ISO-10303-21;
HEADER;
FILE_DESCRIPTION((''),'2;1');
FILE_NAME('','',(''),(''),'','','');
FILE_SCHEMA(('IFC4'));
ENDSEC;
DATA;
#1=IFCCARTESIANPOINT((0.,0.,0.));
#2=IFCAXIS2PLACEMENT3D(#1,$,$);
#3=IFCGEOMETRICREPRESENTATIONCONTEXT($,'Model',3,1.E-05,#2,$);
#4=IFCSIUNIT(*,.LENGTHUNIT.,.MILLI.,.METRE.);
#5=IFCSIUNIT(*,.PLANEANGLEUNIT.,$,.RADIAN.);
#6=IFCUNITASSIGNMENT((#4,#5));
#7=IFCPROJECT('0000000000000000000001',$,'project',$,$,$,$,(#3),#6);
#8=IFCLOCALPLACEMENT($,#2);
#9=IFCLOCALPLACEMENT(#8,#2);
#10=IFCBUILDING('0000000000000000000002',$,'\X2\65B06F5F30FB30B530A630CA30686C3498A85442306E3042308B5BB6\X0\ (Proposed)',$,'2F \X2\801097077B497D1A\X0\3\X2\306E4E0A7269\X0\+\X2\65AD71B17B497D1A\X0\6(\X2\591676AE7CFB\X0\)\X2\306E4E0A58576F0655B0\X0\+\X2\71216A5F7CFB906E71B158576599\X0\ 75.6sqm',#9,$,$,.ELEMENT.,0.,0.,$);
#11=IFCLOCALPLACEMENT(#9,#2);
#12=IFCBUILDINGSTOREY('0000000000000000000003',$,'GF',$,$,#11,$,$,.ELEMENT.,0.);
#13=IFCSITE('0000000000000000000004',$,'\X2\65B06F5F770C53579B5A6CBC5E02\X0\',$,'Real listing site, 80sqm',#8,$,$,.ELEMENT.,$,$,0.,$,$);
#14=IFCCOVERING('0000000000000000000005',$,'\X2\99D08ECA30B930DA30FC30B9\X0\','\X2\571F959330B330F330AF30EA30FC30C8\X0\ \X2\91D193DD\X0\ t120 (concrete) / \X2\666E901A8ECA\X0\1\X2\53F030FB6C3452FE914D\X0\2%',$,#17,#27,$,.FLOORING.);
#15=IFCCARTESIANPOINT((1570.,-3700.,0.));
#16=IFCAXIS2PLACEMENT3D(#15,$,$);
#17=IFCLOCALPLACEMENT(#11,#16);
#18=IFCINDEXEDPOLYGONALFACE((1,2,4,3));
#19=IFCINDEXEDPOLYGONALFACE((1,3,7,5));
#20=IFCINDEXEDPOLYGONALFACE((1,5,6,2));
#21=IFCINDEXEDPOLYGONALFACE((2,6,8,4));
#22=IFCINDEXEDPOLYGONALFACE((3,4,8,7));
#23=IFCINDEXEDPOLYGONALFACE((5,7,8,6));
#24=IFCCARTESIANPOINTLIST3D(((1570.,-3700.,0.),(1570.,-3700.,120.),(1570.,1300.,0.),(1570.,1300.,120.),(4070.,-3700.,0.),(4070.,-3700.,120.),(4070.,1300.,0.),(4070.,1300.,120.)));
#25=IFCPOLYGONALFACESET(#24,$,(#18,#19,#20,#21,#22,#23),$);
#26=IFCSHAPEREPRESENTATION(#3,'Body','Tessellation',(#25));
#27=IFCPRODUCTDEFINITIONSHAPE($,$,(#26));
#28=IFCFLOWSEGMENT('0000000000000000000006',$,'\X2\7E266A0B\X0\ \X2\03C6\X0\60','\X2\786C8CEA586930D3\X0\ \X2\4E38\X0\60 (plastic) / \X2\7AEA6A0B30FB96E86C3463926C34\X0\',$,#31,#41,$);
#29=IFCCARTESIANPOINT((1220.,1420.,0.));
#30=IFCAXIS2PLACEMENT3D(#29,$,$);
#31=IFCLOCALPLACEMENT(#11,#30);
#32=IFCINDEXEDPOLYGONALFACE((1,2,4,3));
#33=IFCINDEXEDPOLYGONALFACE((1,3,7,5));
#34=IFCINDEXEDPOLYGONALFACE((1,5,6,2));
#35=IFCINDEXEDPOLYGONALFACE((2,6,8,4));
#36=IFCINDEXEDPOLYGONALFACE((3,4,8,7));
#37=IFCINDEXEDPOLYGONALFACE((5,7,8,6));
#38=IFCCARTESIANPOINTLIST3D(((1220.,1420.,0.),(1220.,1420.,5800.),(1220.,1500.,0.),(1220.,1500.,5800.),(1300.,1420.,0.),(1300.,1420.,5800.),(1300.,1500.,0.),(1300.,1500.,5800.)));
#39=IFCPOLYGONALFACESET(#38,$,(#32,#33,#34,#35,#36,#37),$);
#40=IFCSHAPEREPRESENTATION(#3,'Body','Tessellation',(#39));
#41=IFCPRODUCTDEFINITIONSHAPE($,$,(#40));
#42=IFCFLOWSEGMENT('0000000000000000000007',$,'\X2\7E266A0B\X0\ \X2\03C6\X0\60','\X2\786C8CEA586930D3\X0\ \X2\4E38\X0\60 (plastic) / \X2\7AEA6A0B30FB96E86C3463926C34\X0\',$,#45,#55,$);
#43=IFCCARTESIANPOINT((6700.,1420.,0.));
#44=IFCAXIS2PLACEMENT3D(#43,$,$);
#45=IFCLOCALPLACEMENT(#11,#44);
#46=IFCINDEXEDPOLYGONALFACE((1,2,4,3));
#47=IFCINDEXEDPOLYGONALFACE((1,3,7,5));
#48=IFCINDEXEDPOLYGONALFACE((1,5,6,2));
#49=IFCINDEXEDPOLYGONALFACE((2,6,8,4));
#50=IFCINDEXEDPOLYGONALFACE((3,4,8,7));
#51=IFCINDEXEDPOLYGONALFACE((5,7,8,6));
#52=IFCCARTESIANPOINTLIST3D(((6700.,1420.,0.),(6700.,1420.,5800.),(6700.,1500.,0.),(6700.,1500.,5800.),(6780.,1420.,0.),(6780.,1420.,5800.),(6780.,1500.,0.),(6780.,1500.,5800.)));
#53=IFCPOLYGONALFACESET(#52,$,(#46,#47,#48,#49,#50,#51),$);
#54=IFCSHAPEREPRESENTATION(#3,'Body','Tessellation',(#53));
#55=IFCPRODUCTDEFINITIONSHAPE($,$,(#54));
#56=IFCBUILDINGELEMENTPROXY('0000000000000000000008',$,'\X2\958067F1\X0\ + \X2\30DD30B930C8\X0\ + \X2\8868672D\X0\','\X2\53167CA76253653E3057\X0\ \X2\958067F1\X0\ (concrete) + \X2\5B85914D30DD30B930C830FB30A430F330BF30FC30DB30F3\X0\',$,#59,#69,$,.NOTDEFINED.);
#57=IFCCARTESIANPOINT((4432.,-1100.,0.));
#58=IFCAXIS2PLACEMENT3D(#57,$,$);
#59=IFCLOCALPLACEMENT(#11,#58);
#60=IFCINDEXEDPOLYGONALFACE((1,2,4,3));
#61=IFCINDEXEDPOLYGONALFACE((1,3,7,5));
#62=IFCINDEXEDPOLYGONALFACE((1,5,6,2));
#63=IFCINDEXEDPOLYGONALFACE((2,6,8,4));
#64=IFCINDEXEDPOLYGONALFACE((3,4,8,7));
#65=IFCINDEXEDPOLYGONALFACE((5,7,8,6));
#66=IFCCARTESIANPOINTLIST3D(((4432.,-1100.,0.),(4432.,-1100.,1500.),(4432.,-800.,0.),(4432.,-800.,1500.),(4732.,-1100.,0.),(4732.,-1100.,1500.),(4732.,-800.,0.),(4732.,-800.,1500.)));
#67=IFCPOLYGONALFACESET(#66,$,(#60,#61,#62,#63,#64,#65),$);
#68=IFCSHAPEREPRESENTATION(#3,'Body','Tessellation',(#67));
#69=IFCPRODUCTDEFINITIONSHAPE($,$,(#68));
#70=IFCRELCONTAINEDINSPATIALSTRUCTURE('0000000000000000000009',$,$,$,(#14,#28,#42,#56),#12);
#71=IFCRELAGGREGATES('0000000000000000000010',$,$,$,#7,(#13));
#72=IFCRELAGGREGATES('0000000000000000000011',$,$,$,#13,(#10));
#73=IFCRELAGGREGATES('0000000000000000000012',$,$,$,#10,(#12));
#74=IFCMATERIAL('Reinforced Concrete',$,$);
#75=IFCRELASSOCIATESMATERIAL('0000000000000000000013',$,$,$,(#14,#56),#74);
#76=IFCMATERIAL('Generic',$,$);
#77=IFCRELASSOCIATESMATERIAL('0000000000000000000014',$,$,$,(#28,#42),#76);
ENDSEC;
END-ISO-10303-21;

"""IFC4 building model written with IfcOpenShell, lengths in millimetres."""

from ifc_helpers import new_model, si_unit, frame, frame_2d, origin, place, context, project, spatial, rectangle, extrude, material, element, save


model = new_model("IFC4")

# Units and contexts
model_context = context("Model", 3, precision=1e-05, world=origin())
ifc_project = project(units=[si_unit("LENGTHUNIT", "METRE", prefix="MILLI"), si_unit("PLANEANGLEUNIT", "RADIAN")], contexts=[model_context])

# Site, building, storey
site_placement = place(None, origin())
site = spatial("IfcSite", under=ifc_project, at=site_placement, Name="新潟県南魚沼市", ObjectType="Real listing site, 80sqm", CompositionType="ELEMENT", RefElevation=0.0)
building_placement = place(site_placement, origin())
building = spatial("IfcBuilding", under=site, at=building_placement, Name="新潟・サウナと水風呂のある家 (Proposed)", ObjectType="2F 耐震等級3の上物+断熱等級6(外皮系)の上塗漆喰+無機系遮熱塗料 75.6sqm", CompositionType="ELEMENT", ElevationOfRefHeight=0.0, ElevationOfTerrain=0.0)
storey_placement = place(building_placement, origin())
storey = spatial("IfcBuildingStorey", under=building, at=storey_placement, Name="GF", CompositionType="ELEMENT", Elevation=0.0)

# Shared definitions
ifc_material_1 = material(Name="Reinforced Concrete")

# Covering
covering_1_placement = place(storey_placement, frame((1570.0, -3700.0, 0.0)))
element("IfcCovering", 1, at=covering_1_placement, inside=storey, material=ifc_material_1, Name="駐車スペース", Description="土間コンクリート 金鏝 t120 (concrete) / 普通車1台・水勾配2%", PredefinedType="FLOORING", context=model_context, shape_type="SweptSolid", body=[
    extrude(rectangle(XDim=2500.0, YDim=5000.0, at=frame_2d((1250.0, 2500.0))), frame((1570.0, -3700.0, 0.0)), (0.0, 0.0, 1.0), 120.0),
])

# Flow segments
ifc_material_2 = material(Name="Generic")
flow_segment_1_placement = place(storey_placement, frame((1220.0, 1420.0, 0.0)))
element("IfcFlowSegment", 2, at=flow_segment_1_placement, inside=storey, material=ifc_material_2, Name="縦樋 φ60", Description="硬質塩ビ 丸60 (plastic) / 竪樋・雨水排水", context=model_context, shape_type="SweptSolid", body=[
    extrude(rectangle(XDim=80.0, YDim=80.0, at=frame_2d((40.0, 40.0))), frame((1220.0, 1420.0, 0.0)), (0.0, 0.0, 1.0), 5800.0),
])
flow_segment_2_placement = place(storey_placement, frame((6700.0, 1420.0, 0.0)))
element("IfcFlowSegment", 3, at=flow_segment_2_placement, inside=storey, material=ifc_material_2, Name="縦樋 φ60", Description="硬質塩ビ 丸60 (plastic) / 竪樋・雨水排水", context=model_context, shape_type="SweptSolid", body=[
    extrude(rectangle(XDim=80.0, YDim=80.0, at=frame_2d((40.0, 40.0))), frame((6700.0, 1420.0, 0.0)), (0.0, 0.0, 1.0), 5800.0),
])

# Building element proxy
proxy_placement = place(storey_placement, frame((4432.0, -1100.0, 0.0)))
element("IfcBuildingElementProxy", 4, at=proxy_placement, inside=storey, material=ifc_material_1, Name="門柱 + ポスト + 表札", Description="化粧打放し 門柱 (concrete) + 宅配ポスト・インターホン", PredefinedType="NOTDEFINED", context=model_context, shape_type="SweptSolid", body=[
    extrude(rectangle(XDim=300.0, YDim=300.0, at=frame_2d((150.0, 150.0))), frame((4432.0, -1100.0, 0.0)), (0.0, 0.0, 1.0), 1500.0),
])

save(model, "model.ifc")
